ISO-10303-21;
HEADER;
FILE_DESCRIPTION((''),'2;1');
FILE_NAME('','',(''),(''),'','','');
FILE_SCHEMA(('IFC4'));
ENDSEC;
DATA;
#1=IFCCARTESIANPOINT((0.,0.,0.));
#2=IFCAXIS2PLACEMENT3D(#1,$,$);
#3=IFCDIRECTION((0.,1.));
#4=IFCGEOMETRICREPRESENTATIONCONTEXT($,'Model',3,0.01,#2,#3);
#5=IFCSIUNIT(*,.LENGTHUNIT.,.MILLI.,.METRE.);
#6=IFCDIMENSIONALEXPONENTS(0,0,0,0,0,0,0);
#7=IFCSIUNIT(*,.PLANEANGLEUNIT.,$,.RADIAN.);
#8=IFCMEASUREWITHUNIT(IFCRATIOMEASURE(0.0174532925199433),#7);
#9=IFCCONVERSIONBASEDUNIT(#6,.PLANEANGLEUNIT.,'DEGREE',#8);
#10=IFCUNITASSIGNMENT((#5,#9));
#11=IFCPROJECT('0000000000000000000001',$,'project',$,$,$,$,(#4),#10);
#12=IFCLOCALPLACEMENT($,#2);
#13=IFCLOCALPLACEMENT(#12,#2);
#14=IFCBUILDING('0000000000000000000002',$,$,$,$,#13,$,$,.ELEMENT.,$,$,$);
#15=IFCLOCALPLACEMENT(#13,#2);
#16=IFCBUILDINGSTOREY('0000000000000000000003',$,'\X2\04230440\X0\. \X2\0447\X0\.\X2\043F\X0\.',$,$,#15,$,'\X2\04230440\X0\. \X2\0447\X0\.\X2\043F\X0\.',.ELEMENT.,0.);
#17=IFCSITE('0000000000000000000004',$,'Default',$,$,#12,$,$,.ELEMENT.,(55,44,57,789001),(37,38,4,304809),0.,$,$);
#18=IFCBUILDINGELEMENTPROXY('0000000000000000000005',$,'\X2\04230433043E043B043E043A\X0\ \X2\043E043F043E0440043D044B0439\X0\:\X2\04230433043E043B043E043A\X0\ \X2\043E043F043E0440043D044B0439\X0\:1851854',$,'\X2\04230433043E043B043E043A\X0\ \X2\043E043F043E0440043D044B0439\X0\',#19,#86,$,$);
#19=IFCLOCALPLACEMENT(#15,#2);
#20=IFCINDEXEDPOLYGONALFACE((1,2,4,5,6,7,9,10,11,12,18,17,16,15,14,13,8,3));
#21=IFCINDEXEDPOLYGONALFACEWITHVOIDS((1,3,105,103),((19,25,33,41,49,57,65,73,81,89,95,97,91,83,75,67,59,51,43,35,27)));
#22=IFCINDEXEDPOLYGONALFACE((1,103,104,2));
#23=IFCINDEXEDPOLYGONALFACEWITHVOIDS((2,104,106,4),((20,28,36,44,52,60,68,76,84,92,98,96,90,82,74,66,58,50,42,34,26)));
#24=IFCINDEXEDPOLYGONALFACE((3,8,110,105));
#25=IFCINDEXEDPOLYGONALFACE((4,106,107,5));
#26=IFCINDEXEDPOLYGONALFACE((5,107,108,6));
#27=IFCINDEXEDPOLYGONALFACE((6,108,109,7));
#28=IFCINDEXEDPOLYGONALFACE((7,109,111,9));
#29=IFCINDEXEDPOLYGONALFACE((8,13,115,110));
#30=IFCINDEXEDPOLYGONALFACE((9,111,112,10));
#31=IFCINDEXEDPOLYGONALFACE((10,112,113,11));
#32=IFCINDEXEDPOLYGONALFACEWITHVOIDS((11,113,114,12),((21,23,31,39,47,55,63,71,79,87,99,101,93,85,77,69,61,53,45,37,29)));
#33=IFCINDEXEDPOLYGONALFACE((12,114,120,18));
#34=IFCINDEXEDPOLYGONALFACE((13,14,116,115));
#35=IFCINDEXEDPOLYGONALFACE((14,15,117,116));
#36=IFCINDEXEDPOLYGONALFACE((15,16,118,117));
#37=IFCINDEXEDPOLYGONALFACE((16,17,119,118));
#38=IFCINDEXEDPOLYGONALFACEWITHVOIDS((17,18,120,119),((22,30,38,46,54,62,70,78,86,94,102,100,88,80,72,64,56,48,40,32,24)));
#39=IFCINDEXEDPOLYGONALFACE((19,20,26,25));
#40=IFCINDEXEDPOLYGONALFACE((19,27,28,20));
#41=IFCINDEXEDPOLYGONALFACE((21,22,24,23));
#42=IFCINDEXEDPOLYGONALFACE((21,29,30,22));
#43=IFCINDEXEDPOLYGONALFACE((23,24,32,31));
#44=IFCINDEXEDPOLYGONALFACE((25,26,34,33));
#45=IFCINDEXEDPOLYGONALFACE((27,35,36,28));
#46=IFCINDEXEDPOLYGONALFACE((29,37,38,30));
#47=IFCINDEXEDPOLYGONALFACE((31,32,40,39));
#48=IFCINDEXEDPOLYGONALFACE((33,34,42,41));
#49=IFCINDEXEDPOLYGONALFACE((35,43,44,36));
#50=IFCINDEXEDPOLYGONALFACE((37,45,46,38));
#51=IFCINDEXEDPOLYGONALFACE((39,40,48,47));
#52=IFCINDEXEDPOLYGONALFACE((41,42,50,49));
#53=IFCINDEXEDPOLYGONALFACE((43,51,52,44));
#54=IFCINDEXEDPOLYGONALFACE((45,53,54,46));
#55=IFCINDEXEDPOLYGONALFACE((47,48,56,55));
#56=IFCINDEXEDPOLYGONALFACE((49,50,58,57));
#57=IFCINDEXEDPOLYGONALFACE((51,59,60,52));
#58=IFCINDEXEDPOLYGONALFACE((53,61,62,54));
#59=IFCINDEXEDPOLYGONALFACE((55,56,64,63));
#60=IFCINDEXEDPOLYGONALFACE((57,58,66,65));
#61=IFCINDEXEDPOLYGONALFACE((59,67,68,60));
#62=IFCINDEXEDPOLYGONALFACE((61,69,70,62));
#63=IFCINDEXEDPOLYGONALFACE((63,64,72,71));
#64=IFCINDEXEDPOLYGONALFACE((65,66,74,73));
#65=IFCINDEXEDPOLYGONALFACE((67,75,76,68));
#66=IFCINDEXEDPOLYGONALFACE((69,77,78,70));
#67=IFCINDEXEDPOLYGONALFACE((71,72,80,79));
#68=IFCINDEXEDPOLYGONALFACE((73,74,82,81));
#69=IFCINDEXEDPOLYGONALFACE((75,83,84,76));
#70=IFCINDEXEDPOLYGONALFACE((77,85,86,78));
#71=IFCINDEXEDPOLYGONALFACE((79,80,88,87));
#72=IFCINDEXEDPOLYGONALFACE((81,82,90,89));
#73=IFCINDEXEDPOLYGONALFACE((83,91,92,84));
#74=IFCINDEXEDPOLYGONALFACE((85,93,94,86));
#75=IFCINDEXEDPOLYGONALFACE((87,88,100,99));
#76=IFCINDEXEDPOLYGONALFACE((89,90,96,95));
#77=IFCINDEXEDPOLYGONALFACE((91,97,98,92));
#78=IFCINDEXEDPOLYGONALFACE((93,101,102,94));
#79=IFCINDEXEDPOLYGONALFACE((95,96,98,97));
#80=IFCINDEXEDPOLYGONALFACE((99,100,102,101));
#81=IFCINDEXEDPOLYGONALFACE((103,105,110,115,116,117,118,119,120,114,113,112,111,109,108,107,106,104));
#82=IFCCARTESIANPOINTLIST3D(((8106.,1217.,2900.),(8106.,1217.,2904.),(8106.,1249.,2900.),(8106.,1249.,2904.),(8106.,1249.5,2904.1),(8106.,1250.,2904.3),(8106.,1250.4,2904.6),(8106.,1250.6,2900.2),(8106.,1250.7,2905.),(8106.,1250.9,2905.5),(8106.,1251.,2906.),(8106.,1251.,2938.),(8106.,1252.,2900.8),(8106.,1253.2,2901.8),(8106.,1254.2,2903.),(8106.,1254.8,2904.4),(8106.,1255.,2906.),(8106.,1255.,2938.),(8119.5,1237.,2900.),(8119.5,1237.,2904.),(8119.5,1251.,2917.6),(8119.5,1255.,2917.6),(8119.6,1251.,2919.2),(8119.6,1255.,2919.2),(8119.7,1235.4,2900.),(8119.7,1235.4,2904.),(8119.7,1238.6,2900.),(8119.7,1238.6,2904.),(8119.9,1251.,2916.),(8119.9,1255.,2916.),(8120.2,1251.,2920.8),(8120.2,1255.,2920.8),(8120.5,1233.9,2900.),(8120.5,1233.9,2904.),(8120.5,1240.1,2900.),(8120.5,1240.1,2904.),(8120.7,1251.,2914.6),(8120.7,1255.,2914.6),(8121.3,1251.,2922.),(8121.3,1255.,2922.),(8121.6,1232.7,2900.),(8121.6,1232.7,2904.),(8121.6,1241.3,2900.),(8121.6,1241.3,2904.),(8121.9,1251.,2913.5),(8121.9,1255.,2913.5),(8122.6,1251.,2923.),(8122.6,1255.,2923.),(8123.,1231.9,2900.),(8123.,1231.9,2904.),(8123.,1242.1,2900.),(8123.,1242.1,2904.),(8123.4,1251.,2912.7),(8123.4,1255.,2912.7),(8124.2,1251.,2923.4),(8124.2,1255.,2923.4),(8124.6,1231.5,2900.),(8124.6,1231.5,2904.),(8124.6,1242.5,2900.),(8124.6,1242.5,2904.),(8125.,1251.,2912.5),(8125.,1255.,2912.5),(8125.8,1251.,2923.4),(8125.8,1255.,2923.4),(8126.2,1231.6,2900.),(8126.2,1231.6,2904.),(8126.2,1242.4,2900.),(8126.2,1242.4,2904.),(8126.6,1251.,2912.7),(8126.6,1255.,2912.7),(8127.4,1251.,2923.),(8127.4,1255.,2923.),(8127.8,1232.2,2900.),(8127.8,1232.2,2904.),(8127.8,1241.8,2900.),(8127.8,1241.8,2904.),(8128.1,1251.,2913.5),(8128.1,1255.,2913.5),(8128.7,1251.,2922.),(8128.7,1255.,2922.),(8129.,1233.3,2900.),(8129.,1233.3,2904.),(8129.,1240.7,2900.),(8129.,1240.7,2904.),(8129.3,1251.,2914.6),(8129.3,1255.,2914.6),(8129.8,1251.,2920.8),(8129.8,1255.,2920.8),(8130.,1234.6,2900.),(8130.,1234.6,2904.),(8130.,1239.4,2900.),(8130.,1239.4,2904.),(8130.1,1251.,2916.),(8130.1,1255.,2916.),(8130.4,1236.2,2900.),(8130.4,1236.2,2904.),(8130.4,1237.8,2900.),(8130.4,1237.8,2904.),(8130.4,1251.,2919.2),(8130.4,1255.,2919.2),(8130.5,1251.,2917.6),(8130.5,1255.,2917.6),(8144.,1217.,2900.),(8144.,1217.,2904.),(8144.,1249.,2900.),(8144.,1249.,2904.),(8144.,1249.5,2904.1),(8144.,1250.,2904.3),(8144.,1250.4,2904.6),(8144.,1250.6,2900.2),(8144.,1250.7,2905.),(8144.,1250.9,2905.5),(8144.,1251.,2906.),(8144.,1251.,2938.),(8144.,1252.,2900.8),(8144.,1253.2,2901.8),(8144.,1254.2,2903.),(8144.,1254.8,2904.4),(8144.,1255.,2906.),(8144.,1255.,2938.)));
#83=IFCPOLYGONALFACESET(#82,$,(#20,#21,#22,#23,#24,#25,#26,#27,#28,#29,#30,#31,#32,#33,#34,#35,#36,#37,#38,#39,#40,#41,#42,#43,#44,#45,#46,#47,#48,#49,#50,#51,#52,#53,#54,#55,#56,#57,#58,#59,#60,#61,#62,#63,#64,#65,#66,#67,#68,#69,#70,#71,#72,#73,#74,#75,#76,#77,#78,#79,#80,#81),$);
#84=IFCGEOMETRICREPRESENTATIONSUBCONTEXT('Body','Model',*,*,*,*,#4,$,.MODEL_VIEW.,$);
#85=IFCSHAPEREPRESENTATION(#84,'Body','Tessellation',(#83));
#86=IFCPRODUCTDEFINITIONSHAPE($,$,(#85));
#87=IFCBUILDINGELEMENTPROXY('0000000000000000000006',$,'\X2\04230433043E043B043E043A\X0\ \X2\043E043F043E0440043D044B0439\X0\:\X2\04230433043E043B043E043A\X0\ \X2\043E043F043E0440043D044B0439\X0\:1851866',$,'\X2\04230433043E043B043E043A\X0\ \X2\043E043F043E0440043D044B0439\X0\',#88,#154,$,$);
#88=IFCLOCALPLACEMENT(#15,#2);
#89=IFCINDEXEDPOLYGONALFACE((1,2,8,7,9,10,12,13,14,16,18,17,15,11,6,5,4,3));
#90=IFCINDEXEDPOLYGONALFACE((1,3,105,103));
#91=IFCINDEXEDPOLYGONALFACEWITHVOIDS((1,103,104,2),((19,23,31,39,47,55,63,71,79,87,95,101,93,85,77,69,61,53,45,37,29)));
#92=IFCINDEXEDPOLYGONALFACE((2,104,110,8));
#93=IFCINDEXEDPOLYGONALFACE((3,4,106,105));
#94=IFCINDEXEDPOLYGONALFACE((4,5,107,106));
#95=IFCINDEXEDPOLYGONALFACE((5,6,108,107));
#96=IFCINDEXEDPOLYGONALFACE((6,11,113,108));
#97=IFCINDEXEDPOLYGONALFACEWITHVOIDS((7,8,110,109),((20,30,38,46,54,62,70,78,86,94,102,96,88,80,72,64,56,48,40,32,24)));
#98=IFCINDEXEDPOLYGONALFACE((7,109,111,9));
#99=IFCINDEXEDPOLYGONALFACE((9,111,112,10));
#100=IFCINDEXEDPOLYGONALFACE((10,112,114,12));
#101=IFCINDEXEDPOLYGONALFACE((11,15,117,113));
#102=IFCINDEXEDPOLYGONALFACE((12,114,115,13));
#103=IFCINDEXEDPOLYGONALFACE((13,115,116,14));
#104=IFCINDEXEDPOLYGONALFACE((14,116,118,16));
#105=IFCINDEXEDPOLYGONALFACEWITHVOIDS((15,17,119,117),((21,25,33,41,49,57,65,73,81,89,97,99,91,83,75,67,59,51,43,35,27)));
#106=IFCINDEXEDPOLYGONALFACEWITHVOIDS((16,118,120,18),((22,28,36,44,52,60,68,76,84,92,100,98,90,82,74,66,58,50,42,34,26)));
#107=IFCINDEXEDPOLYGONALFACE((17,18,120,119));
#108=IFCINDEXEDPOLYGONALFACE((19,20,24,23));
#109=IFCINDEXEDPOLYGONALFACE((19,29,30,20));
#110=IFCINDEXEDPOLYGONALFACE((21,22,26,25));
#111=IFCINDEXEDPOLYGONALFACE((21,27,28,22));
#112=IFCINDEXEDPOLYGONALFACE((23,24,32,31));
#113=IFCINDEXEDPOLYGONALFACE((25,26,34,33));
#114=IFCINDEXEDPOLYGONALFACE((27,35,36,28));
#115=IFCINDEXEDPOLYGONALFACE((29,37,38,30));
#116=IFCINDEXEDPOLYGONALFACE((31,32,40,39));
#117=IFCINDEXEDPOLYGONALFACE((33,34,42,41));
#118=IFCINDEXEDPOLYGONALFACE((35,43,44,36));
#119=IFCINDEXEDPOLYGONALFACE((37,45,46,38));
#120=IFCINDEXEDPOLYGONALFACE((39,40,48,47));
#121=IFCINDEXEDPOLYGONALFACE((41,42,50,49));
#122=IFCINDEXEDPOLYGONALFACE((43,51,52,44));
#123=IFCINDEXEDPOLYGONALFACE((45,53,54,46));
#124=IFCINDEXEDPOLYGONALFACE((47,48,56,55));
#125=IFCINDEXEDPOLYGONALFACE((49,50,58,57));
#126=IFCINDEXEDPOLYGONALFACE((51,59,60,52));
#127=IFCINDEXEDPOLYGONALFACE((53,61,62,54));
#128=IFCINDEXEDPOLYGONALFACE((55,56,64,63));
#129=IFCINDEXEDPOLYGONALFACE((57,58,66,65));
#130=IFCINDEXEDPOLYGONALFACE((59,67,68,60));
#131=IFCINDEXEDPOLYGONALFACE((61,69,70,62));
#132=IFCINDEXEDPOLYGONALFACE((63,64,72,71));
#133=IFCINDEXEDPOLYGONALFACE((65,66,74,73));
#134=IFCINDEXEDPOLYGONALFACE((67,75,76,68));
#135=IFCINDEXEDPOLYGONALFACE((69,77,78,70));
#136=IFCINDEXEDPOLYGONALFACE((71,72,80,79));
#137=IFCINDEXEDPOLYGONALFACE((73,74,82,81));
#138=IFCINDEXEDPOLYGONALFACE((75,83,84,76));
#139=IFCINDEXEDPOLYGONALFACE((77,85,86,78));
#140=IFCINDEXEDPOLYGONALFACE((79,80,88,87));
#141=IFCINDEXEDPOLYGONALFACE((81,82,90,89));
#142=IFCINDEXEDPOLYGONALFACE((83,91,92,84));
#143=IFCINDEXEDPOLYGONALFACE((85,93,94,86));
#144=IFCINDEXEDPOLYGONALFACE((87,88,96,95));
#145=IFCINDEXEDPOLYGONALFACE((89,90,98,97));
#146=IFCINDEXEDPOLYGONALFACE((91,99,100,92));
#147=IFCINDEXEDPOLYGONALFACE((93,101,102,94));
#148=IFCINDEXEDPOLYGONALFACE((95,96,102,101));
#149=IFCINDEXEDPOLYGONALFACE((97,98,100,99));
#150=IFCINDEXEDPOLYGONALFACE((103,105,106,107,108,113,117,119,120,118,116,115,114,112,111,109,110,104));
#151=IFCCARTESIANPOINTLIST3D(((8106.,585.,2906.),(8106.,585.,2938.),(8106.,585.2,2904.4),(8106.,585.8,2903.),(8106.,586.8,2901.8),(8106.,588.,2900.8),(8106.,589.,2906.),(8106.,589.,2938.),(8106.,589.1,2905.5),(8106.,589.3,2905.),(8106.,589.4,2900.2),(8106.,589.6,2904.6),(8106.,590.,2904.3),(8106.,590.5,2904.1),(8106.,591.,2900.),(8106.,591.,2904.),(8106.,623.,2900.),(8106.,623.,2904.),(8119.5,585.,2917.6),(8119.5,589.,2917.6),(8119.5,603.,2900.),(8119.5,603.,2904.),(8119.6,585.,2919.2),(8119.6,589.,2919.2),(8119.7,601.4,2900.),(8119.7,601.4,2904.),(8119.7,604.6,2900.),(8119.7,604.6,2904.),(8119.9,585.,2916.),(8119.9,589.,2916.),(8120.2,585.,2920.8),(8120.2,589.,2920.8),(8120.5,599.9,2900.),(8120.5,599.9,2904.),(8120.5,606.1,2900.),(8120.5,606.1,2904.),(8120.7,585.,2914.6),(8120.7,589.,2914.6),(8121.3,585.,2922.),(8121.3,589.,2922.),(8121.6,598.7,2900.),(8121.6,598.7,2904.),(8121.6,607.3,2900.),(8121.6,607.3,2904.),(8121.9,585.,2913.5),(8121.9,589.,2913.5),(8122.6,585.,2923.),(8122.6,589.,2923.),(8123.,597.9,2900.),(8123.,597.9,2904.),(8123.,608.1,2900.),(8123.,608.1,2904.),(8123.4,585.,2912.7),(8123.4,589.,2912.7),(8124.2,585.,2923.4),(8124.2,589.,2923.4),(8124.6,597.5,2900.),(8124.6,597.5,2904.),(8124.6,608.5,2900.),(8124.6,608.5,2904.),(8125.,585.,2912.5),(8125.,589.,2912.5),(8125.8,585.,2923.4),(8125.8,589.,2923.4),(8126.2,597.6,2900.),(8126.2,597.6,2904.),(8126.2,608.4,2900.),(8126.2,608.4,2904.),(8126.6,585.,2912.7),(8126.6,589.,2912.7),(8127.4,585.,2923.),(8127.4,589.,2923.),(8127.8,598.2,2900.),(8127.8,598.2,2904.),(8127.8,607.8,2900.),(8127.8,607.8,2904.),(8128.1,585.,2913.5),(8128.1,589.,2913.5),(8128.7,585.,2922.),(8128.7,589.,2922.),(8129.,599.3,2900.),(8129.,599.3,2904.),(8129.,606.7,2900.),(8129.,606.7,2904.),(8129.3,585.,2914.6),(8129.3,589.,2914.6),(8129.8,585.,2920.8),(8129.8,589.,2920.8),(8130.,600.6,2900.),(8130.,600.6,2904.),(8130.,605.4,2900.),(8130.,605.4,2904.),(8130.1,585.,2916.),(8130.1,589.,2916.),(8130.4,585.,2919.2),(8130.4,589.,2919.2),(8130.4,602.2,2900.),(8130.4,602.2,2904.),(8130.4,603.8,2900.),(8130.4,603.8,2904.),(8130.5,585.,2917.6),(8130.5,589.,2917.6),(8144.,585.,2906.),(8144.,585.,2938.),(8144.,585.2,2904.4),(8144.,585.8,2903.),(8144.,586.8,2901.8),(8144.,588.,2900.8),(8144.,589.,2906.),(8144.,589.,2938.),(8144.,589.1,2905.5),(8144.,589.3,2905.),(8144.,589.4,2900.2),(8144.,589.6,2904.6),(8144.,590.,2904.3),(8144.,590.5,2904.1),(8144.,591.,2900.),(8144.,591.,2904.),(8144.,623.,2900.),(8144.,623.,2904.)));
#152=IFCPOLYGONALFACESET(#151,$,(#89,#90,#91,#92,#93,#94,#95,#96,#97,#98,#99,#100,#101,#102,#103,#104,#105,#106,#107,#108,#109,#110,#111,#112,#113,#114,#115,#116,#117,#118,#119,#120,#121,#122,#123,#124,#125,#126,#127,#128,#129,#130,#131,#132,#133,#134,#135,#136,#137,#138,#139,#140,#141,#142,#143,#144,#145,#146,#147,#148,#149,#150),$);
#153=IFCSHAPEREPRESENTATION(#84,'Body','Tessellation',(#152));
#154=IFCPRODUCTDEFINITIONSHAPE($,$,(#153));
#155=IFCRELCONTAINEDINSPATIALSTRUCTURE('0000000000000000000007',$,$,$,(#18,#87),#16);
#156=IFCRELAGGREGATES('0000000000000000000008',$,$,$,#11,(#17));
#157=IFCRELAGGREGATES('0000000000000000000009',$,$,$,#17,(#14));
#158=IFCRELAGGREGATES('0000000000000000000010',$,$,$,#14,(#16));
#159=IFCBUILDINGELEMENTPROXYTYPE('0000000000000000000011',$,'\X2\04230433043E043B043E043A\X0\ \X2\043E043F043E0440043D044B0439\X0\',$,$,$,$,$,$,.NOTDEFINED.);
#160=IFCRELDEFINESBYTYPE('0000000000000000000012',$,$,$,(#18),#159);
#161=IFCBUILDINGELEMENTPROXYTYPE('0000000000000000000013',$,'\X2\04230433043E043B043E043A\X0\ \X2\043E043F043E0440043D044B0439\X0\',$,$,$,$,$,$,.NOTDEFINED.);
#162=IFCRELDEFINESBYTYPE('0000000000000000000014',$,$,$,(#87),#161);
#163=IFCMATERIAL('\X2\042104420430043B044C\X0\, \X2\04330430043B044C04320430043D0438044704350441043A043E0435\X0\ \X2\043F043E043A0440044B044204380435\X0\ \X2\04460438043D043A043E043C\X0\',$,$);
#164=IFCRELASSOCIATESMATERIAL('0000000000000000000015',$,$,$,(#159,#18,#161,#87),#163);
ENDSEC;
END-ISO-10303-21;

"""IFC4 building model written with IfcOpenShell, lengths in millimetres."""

from ifc_helpers import new_model, entity, si_unit, converted_unit, direction, frame, frame_2d, origin, place, context, subcontext, project, spatial, polyline, circle_curve, parameter, trimmed, segment, composite_curve, circle, outline, extrude, source, transform, mapped, material, type_object, type_shapes, element, save


model = new_model("IFC4")

# Units and contexts
model_context = context("Model", 3, precision=0.01, world=origin(), true_north=direction((0.0, 1.0)))
body_context = subcontext(model_context, "Body", "Model", "MODEL_VIEW")
ifc_project = project(units=[si_unit("LENGTHUNIT", "METRE", prefix="MILLI"), converted_unit("PLANEANGLEUNIT", "DEGREE", entity("IfcRatioMeasure", 0.0174532925199433), si_unit("PLANEANGLEUNIT", "RADIAN"), dimensions=[0, 0, 0, 0, 0, 0, 0])], contexts=[model_context])

# Site, building, storey
site_placement = place(None, origin())
site = spatial("IfcSite", under=ifc_project, at=site_placement, Name="Default", CompositionType="ELEMENT", RefLatitude=(55, 44, 57, 789001), RefLongitude=(37, 38, 4, 304809), RefElevation=0.0)
building_placement = place(site_placement, origin())
building = spatial("IfcBuilding", under=site, at=building_placement, CompositionType="ELEMENT")
storey_placement = place(building_placement, origin())
storey = spatial("IfcBuildingStorey", under=building, at=storey_placement, Name="Ур. ч.п.", LongName="Ур. ч.п.", CompositionType="ELEMENT", Elevation=0.0)

# Building element proxies, openings
ifc_material = material(Name="Сталь, гальваническое покрытие цинком")
building_element_proxy_type_1 = type_object("IfcBuildingElementProxyType", Name="Уголок опорный", material=ifc_material)
shared_shape_1 = source(origin(), body_context, "Body", "SweptSolid", [
    extrude(outline(composite_curve([segment(polyline([(-6.0, -12.0), (26.0, -12.0)]), True, "CONTINUOUS"), segment(polyline([(26.0, -12.0), (26.0, -8.0)]), True, "CONTINUOUS"), segment(polyline([(26.0, -8.0), (-6.0, -8.0)]), True, "CONTINUOUS"), segment(trimmed(circle_curve(frame_2d((-6.0, -6.0), x_axis=(0.0, -1.0)), 2.0), [parameter(270.0)], [parameter(0.0)], True, "PARAMETER"), False, "CONTINUOUS"), segment(polyline([(-8.0, -6.0), (-8.0, 26.0)]), True, "CONTINUOUS"), segment(polyline([(-8.0, 26.0), (-12.0, 26.0)]), True, "CONTINUOUS"), segment(polyline([(-12.0, 26.0), (-12.0, -6.0)]), True, "CONTINUOUS"), segment(trimmed(circle_curve(frame_2d((-6.0, -6.0), x_axis=(0.0, -1.0)), 6.0), [parameter(270.0)], [parameter(360.0)], True, "PARAMETER"), True, "CONTINUOUS")], self_intersect=False)), frame((12.0, -19.0, 12.0), z_axis=(0.0, 1.0, 0.0), x_axis=(0.0, 0.0, 1.0)), (0.0, 0.0, 1.0), 38.0),
])
type_shapes(building_element_proxy_type_1, [shared_shape_1])
proxy_1_placement = place(storey_placement, frame((8125.0, 1255.0, 2900.0), z_axis=(0.0, 0.0, 1.0), x_axis=(0.0, -1.0, 0.0)))
proxy_1 = element("IfcBuildingElementProxy", 1, at=proxy_1_placement, inside=storey, type_object=building_element_proxy_type_1, material=ifc_material, Name="Уголок опорный:Уголок опорный:1851854", ObjectType="Уголок опорный", context=body_context, shape_type="MappedRepresentation", body=[
    mapped(shared_shape_1, transform((0.0, 0.0, 0.0), scale=1.0)),
])
opening_1_placement = place(storey_placement, frame((8125.0, 1255.0, 2900.0), z_axis=(0.0, 0.0, 1.0), x_axis=(-1.0, 0.0, 0.0)))
element("IfcOpeningElement", 2, at=opening_1_placement, cuts=proxy_1, ObjectType="Opening", PredefinedType="OPENING", context=body_context, shape_type="SweptSolid", body=[
    extrude(circle(Radius=5.5, at=frame_2d((0.0, 0.0), x_axis=(1.0, 0.0))), frame((0.0, 0.0, 18.0), z_axis=(0.0, 1.0, 0.0), x_axis=(0.0, 0.0, -1.0)), (0.0, 0.0, 1.0), 4.0),
])
opening_2_placement = place(storey_placement, frame((8125.0, 1255.0, 2900.0), z_axis=(0.0, 0.0, 1.0), x_axis=(-1.0, 0.0, 0.0)))
element("IfcOpeningElement", 3, at=opening_2_placement, cuts=proxy_1, ObjectType="Opening", PredefinedType="OPENING", context=body_context, shape_type="SweptSolid", body=[
    extrude(circle(Radius=5.5, at=frame_2d((0.0, 0.0), x_axis=(1.0, 0.0))), frame((0.0, 18.0, 0.0)), (0.0, 0.0, 1.0), 4.0),
])
building_element_proxy_type_2 = type_object("IfcBuildingElementProxyType", Name="Уголок опорный", material=ifc_material)
shared_shape_2 = source(origin(), body_context, "Body", "SweptSolid", [
    extrude(outline(composite_curve([segment(polyline([(-6.0, -12.0), (26.0, -12.0)]), True, "CONTINUOUS"), segment(polyline([(26.0, -12.0), (26.0, -8.0)]), True, "CONTINUOUS"), segment(polyline([(26.0, -8.0), (-6.0, -8.0)]), True, "CONTINUOUS"), segment(trimmed(circle_curve(frame_2d((-6.0, -6.0), x_axis=(0.0, -1.0)), 2.0), [parameter(270.0)], [parameter(0.0)], True, "PARAMETER"), False, "CONTINUOUS"), segment(polyline([(-8.0, -6.0), (-8.0, 26.0)]), True, "CONTINUOUS"), segment(polyline([(-8.0, 26.0), (-12.0, 26.0)]), True, "CONTINUOUS"), segment(polyline([(-12.0, 26.0), (-12.0, -6.0)]), True, "CONTINUOUS"), segment(trimmed(circle_curve(frame_2d((-6.0, -6.0), x_axis=(0.0, -1.0)), 6.0), [parameter(270.0)], [parameter(360.0)], True, "PARAMETER"), True, "CONTINUOUS")], self_intersect=False)), frame((12.0, -19.0, 12.0), z_axis=(0.0, 1.0, 0.0), x_axis=(0.0, 0.0, 1.0)), (0.0, 0.0, 1.0), 38.0),
])
type_shapes(building_element_proxy_type_2, [shared_shape_2])
proxy_2_placement = place(storey_placement, frame((8125.0, 585.0, 2900.0), z_axis=(0.0, 0.0, 1.0), x_axis=(0.0, 1.0, 0.0)))
proxy_2 = element("IfcBuildingElementProxy", 4, at=proxy_2_placement, inside=storey, type_object=building_element_proxy_type_2, material=ifc_material, Name="Уголок опорный:Уголок опорный:1851866", ObjectType="Уголок опорный", context=body_context, shape_type="MappedRepresentation", body=[
    mapped(shared_shape_2, transform((0.0, 0.0, 0.0), scale=1.0)),
])
opening_3_placement = place(storey_placement, frame((8125.0, 585.0, 2900.0), z_axis=(0.0, 0.0, 1.0), x_axis=(-1.0, 0.0, 0.0)))
element("IfcOpeningElement", 5, at=opening_3_placement, cuts=proxy_2, ObjectType="Opening", PredefinedType="OPENING", context=body_context, shape_type="SweptSolid", body=[
    extrude(circle(Radius=5.5, at=frame_2d((0.0, 0.0), x_axis=(1.0, 0.0))), frame((0.0, -4.0, 18.0), z_axis=(0.0, 1.0, 0.0), x_axis=(0.0, 0.0, -1.0)), (0.0, 0.0, 1.0), 4.0),
])
opening_4_placement = place(storey_placement, frame((8125.0, 585.0, 2900.0), z_axis=(0.0, 0.0, 1.0), x_axis=(-1.0, 0.0, 0.0)))
element("IfcOpeningElement", 6, at=opening_4_placement, cuts=proxy_2, ObjectType="Opening", PredefinedType="OPENING", context=body_context, shape_type="SweptSolid", body=[
    extrude(circle(Radius=5.5, at=frame_2d((0.0, 0.0), x_axis=(1.0, 0.0))), frame((0.0, -18.0, 0.0)), (0.0, 0.0, 1.0), 4.0),
])

save(model, "model.ifc")
